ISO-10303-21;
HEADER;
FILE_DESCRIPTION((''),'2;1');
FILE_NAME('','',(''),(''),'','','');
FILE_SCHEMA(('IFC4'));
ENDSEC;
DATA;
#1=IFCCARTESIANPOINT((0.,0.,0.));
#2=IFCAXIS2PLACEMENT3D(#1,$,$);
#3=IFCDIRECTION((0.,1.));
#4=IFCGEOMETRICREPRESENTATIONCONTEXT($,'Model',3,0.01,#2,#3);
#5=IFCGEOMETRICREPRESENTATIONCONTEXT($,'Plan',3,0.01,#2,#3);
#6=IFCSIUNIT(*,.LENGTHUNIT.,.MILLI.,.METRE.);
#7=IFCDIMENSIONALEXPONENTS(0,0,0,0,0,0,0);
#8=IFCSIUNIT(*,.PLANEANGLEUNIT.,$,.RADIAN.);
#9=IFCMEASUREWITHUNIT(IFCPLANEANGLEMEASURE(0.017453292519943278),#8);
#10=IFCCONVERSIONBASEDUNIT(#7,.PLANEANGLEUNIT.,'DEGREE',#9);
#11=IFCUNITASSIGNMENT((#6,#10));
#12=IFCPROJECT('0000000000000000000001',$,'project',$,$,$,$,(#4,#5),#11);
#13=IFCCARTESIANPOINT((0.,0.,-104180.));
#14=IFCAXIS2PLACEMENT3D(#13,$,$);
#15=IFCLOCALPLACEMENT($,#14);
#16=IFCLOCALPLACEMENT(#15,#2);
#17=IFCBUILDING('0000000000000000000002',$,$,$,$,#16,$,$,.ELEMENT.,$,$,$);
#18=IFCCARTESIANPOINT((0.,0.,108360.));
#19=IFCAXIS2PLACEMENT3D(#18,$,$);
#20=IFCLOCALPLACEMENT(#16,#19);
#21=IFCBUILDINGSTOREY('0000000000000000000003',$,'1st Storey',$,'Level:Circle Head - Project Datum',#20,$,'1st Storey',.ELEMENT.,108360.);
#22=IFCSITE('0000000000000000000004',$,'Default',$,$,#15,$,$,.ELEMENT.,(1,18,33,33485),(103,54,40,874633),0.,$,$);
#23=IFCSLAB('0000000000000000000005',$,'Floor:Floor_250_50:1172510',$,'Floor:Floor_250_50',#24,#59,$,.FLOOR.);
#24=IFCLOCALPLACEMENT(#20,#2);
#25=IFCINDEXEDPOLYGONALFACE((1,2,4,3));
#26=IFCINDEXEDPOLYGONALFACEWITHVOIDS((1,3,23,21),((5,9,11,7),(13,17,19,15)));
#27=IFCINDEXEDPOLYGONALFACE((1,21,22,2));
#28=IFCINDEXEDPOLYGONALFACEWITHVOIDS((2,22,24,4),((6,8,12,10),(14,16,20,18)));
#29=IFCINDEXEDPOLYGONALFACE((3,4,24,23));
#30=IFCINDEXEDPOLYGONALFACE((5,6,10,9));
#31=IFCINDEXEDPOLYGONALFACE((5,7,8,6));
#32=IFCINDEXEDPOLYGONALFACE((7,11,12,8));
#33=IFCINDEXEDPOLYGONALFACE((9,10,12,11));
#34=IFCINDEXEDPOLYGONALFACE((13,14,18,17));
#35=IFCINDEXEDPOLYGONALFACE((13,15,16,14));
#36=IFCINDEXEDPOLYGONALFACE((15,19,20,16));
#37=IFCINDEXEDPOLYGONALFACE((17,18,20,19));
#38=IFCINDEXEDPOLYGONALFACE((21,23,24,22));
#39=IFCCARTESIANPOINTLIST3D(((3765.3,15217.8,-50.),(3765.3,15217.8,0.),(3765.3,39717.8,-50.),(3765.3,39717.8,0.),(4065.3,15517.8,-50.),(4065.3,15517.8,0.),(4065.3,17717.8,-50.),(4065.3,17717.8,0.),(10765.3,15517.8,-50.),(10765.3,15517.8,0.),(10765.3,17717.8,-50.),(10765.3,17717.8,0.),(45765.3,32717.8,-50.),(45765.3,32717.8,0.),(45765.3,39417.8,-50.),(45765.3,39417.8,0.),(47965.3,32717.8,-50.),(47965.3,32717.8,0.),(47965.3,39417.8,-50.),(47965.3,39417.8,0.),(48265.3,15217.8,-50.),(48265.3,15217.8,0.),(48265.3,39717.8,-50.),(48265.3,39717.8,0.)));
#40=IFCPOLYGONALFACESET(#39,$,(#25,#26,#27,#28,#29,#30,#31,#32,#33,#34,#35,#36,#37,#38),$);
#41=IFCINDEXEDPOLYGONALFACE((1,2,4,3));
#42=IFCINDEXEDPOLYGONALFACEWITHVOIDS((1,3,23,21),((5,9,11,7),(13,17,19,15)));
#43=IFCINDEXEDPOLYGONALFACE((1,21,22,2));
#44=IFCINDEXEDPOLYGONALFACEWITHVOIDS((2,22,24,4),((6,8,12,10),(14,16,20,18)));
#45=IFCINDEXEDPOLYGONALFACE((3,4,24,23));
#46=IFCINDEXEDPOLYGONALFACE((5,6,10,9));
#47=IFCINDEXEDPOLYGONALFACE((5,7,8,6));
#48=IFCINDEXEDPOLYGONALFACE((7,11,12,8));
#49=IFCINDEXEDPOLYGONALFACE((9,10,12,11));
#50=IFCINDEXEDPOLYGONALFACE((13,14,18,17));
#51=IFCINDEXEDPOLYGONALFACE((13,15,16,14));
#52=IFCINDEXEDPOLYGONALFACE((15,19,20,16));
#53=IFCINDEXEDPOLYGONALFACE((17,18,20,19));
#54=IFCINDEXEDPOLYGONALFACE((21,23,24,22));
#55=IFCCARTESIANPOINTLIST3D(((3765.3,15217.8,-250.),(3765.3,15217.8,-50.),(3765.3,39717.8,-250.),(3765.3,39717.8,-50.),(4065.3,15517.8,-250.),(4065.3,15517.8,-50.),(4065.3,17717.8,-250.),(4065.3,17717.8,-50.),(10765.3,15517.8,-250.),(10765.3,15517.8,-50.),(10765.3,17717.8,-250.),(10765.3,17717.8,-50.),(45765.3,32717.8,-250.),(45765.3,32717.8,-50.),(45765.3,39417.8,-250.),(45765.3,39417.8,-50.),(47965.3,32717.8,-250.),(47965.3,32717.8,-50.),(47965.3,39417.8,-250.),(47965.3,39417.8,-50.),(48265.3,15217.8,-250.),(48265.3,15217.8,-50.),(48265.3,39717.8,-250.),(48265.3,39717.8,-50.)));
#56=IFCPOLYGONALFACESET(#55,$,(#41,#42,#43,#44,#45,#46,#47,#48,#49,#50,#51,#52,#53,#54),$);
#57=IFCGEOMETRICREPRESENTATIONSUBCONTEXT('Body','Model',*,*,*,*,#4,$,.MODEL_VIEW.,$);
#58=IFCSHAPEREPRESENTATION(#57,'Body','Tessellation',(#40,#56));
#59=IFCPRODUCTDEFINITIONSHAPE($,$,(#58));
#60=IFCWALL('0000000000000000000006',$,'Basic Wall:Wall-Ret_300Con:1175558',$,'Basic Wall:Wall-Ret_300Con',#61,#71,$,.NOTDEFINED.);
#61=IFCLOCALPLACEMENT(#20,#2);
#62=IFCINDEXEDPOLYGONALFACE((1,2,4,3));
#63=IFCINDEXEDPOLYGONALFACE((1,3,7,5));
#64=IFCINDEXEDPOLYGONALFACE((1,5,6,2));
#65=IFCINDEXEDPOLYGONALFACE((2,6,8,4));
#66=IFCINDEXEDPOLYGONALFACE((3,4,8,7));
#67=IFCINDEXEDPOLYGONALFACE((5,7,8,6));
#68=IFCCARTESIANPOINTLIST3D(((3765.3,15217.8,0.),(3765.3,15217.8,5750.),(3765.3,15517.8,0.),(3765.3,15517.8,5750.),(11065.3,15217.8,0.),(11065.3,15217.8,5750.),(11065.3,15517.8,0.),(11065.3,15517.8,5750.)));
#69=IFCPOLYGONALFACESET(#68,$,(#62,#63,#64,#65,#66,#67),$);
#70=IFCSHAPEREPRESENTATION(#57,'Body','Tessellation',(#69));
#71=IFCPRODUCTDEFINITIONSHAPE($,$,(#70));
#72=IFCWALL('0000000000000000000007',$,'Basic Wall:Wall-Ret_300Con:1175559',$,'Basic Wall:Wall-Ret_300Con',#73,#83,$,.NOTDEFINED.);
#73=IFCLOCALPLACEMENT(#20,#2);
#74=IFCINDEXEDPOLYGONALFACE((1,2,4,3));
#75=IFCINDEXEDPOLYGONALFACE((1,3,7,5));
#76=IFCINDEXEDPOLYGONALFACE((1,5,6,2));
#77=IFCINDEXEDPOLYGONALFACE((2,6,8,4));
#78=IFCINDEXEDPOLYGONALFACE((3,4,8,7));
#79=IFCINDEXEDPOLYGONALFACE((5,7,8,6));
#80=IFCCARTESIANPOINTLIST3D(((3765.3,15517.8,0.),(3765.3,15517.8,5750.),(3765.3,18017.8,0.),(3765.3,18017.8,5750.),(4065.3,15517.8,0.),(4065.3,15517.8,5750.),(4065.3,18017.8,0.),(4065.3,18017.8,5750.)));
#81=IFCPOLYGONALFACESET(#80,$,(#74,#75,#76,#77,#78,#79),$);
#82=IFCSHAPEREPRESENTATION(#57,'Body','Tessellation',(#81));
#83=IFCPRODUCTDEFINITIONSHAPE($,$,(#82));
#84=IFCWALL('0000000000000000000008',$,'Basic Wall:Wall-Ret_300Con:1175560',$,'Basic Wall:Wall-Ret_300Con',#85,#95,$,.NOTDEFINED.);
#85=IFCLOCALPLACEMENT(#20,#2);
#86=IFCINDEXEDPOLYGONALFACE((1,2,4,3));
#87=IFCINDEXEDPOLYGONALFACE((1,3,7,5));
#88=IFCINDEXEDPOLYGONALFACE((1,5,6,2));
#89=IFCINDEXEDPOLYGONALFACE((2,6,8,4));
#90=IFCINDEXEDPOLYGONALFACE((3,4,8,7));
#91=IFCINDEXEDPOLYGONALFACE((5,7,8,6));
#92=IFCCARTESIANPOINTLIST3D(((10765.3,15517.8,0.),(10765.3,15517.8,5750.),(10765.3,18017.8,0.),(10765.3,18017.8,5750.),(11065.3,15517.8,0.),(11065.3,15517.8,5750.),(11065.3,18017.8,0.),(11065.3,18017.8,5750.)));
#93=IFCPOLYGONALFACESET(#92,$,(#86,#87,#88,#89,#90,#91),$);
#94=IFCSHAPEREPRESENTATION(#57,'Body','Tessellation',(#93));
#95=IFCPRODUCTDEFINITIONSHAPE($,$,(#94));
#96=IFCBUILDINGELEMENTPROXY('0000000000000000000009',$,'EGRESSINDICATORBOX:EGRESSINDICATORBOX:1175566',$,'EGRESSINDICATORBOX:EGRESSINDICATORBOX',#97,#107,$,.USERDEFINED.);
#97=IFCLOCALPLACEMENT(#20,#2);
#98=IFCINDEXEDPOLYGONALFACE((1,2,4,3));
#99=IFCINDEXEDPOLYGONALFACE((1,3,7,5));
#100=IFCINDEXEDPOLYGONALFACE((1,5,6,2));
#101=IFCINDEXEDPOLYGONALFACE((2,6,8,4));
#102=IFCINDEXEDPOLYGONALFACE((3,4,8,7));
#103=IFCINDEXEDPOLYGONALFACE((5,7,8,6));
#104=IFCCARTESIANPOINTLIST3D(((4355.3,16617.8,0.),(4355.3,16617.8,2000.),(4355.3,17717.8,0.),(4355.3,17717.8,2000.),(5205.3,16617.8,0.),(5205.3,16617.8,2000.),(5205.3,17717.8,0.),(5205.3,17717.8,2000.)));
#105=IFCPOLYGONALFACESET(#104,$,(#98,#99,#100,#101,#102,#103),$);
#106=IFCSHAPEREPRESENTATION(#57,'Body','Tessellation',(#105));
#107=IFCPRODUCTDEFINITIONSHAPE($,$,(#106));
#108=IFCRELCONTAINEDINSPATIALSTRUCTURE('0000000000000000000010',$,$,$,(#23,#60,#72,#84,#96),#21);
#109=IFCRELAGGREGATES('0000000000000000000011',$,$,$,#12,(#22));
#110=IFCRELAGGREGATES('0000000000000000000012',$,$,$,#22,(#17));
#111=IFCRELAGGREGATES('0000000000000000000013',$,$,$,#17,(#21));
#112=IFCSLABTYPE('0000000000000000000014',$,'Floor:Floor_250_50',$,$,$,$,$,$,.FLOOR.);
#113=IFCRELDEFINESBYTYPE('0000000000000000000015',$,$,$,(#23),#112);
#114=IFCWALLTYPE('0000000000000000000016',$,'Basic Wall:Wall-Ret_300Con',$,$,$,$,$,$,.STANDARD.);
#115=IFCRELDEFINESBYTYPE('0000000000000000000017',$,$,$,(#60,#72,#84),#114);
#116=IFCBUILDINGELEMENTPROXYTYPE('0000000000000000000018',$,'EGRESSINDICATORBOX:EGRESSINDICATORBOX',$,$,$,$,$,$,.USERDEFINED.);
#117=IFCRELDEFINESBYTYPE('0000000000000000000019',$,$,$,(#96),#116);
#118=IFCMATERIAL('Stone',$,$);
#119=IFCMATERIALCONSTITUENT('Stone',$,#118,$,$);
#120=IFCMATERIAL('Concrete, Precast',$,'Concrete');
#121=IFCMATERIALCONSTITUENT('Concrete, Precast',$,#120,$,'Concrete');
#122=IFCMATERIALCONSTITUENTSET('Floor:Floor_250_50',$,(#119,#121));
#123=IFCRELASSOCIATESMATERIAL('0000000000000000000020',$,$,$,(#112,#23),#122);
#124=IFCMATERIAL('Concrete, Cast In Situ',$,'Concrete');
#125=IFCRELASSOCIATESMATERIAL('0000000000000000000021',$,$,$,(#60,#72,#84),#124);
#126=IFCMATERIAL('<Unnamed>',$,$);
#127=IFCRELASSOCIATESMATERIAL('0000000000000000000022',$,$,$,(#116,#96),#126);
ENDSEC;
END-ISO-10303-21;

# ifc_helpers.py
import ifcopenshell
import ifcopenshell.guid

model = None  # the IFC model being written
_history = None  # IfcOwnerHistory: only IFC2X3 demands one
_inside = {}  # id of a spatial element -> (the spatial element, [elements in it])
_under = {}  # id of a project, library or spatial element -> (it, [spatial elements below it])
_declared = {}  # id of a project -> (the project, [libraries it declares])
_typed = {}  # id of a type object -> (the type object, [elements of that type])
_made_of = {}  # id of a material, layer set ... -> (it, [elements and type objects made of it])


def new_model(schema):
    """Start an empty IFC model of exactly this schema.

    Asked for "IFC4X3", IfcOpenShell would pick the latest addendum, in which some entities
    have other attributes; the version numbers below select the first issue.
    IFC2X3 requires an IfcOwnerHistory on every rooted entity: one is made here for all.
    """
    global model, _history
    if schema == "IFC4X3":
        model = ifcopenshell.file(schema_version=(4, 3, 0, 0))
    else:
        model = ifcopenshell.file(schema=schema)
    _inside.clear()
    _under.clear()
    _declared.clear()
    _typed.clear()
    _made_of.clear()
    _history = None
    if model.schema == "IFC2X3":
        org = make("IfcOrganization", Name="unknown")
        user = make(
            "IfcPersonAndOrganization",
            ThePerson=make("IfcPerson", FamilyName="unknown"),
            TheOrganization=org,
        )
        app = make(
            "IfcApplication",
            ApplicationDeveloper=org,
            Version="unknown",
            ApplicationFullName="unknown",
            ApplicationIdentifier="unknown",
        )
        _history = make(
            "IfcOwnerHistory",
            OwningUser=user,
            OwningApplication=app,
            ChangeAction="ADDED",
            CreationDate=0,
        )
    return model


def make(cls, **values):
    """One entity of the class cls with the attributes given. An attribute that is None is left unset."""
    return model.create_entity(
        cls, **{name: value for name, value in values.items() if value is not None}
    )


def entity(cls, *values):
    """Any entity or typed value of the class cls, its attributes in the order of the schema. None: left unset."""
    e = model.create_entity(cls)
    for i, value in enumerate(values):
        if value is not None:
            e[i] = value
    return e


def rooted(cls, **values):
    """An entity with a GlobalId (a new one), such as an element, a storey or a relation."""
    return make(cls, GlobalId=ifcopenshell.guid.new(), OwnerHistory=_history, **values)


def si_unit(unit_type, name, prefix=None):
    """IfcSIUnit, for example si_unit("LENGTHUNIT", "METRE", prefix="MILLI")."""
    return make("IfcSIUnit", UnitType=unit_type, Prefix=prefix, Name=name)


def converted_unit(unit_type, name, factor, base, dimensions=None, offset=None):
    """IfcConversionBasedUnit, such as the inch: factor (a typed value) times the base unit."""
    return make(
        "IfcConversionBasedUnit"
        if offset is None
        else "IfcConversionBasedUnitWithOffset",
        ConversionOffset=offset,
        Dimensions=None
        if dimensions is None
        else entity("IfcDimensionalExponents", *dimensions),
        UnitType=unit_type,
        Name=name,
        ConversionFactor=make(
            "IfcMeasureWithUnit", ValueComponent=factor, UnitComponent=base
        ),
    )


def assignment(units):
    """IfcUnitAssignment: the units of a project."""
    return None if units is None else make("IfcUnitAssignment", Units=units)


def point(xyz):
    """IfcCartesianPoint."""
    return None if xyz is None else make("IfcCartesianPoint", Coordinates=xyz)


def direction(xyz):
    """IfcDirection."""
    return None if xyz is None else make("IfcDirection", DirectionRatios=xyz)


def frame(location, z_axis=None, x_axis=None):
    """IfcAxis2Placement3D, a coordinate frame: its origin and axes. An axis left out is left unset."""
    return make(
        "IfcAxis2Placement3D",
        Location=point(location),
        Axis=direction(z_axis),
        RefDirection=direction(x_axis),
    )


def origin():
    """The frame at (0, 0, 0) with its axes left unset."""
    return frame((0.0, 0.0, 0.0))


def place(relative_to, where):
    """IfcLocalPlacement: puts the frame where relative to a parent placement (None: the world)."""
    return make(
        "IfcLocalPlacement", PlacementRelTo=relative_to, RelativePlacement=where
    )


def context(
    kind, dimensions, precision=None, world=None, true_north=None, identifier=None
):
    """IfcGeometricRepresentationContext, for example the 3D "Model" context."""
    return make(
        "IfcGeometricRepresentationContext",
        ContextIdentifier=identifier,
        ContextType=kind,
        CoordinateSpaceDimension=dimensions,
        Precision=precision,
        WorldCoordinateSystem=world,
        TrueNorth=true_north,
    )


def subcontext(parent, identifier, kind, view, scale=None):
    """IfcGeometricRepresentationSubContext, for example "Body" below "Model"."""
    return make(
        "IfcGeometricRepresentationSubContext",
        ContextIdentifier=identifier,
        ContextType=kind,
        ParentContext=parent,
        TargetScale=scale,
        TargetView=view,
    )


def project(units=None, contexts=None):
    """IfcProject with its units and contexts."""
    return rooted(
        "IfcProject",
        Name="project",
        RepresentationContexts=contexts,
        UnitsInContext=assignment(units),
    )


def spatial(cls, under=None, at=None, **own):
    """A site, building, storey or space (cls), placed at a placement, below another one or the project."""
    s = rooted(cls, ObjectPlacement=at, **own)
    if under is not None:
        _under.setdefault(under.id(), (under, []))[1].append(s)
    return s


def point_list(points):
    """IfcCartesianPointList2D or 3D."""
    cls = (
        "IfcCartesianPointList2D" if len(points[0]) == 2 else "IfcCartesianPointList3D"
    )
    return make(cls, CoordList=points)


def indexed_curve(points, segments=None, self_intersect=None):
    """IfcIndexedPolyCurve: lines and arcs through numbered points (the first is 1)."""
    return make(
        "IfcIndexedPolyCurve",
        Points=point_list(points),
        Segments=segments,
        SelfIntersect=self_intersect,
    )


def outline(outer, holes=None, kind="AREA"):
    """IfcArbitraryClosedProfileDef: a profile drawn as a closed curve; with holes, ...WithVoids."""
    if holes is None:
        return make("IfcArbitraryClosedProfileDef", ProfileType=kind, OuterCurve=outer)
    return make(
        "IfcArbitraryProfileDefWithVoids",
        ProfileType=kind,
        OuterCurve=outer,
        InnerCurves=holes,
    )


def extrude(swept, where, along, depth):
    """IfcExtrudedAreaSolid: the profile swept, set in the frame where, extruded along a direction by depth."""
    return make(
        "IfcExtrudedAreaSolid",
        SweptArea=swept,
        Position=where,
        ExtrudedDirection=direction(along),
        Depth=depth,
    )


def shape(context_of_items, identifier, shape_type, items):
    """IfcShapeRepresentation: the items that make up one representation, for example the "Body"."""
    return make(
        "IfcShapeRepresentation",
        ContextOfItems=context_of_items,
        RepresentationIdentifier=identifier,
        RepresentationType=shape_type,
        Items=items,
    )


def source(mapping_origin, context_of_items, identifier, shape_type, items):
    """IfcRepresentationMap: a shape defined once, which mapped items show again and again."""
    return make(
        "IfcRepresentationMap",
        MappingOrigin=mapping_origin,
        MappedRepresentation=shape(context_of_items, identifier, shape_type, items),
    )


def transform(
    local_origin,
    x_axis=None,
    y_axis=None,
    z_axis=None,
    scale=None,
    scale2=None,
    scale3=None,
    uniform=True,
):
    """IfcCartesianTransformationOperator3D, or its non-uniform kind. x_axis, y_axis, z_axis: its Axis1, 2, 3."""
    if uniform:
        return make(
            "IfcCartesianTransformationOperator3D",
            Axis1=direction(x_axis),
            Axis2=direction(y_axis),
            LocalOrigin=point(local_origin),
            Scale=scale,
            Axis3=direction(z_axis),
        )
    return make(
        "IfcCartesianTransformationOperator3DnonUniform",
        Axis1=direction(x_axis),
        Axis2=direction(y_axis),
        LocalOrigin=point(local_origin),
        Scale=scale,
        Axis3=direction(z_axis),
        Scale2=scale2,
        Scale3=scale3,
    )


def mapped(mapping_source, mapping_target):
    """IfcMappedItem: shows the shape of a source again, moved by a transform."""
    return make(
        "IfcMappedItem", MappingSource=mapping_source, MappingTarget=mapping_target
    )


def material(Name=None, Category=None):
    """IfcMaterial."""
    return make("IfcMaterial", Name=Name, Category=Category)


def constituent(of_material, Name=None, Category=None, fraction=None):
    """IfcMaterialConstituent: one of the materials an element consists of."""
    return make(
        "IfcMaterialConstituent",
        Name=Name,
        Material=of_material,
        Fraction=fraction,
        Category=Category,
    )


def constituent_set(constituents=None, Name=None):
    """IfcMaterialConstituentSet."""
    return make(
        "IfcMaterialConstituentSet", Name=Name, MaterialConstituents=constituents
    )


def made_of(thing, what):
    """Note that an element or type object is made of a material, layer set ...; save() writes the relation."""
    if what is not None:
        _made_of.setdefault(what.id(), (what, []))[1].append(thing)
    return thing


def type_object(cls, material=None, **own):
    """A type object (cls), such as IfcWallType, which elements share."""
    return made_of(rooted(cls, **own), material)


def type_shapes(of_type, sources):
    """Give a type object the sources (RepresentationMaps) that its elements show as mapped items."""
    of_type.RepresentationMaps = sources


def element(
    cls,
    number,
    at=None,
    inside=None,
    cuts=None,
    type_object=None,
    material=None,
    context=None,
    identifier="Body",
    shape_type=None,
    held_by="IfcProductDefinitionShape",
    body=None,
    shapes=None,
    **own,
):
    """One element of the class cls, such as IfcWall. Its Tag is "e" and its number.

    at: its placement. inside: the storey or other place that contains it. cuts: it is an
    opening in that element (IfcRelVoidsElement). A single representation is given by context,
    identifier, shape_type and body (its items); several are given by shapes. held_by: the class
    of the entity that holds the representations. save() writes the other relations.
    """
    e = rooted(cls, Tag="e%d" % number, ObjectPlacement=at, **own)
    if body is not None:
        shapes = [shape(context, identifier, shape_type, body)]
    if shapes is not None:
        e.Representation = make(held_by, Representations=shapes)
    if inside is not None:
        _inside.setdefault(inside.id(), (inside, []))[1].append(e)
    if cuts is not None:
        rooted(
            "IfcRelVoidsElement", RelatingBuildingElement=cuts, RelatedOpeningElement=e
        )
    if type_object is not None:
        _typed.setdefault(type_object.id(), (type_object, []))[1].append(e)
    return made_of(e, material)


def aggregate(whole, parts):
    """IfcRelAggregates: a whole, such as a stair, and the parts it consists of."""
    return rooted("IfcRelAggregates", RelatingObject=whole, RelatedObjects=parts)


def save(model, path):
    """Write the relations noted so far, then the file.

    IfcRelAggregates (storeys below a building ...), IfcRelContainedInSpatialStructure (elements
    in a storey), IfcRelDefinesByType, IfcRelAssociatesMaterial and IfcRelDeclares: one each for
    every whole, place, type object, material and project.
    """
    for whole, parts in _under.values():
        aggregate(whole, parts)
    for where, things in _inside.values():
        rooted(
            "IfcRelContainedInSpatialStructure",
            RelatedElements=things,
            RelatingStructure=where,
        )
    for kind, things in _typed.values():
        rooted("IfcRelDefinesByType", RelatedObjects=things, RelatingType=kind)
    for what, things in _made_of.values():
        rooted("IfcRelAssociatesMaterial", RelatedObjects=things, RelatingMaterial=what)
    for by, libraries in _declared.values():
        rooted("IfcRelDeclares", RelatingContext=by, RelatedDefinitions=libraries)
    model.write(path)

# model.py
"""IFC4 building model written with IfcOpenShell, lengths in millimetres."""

from ifc_helpers import new_model, entity, si_unit, converted_unit, direction, frame, origin, place, context, subcontext, project, spatial, indexed_curve, outline, extrude, source, transform, mapped, material, constituent, constituent_set, type_object, type_shapes, element, save


model = new_model("IFC4")

# Units and contexts
model_context = context("Model", 3, precision=0.01, world=origin(), true_north=direction((0.0, 1.0)))
plan_context = context("Plan", 3, precision=0.01, world=origin(), true_north=direction((0.0, 1.0)))
body_context = subcontext(model_context, "Body", "Model", "MODEL_VIEW")
ifc_project = project(units=[si_unit("LENGTHUNIT", "METRE", prefix="MILLI"), converted_unit("PLANEANGLEUNIT", "DEGREE", entity("IfcPlaneAngleMeasure", 0.017453292519943278), si_unit("PLANEANGLEUNIT", "RADIAN"), dimensions=[0, 0, 0, 0, 0, 0, 0])], contexts=[model_context, plan_context])

# Site, building, storey
site_placement = place(None, frame((0.0, 0.0, -104180.0)))
site = spatial("IfcSite", under=ifc_project, at=site_placement, Name="Default", CompositionType="ELEMENT", RefLatitude=(1, 18, 33, 33485), RefLongitude=(103, 54, 40, 874633), RefElevation=0.0)
building_placement = place(site_placement, origin())
building = spatial("IfcBuilding", under=site, at=building_placement, CompositionType="ELEMENT")
storey_placement = place(building_placement, frame((0.0, 0.0, 108360.0)))
storey = spatial("IfcBuildingStorey", under=building, at=storey_placement, Name="1st Storey", ObjectType="Level:Circle Head - Project Datum", LongName="1st Storey", CompositionType="ELEMENT", Elevation=108360.0)

# Slab, openings
ifc_material_1 = material(Name="Stone")
ifc_constituent_1 = constituent(ifc_material_1, Name="Stone")
ifc_material_2 = material(Name="Concrete, Precast", Category="Concrete")
ifc_constituent_2 = constituent(ifc_material_2, Name="Concrete, Precast", Category="Concrete")
ifc_constituent_set = constituent_set(constituents=[ifc_constituent_1, ifc_constituent_2], Name="Floor:Floor_250_50")
slab_type_1 = type_object("IfcSlabType", Name="Floor:Floor_250_50", PredefinedType="FLOOR", material=ifc_constituent_set)
slab_1_placement = place(storey_placement, origin())
slab_1 = element("IfcSlab", 1, at=slab_1_placement, inside=storey, type_object=slab_type_1, material=ifc_constituent_set, Name="Floor:Floor_250_50:1172510", ObjectType="Floor:Floor_250_50", PredefinedType="FLOOR", context=body_context, shape_type="SweptSolid", body=[
    extrude(outline(indexed_curve([(-22250.0, -12250.0), (22250.0, -12250.0), (22250.0, 12250.0), (-22250.0, 12250.0), (-22250.0, -12250.0)], self_intersect=False), holes=[indexed_curve([(-21950.0, -11950.0), (-21950.0, -5250.0), (-19750.0, -5250.0), (-19750.0, -11950.0), (-21950.0, -11950.0)], self_intersect=False), indexed_curve([(21950.0, 9750.0), (15250.0, 9750.0), (15250.0, 11950.0), (21950.0, 11950.0), (21950.0, 9750.0)], self_intersect=False)]), frame((26015.3, 27467.8, -50.0), z_axis=(0.0, 0.0, 1.0), x_axis=(-1.0, 0.0, 0.0)), (0.0, 0.0, 1.0), 50.0),
    extrude(outline(indexed_curve([(-22250.0, -12250.0), (22250.0, -12250.0), (22250.0, 12250.0), (-22250.0, 12250.0), (-22250.0, -12250.0)], self_intersect=False), holes=[indexed_curve([(21950.0, 9750.0), (15250.0, 9750.0), (15250.0, 11950.0), (21950.0, 11950.0), (21950.0, 9750.0)], self_intersect=False), indexed_curve([(-21950.0, -11950.0), (-21950.0, -5250.0), (-19750.0, -5250.0), (-19750.0, -11950.0), (-21950.0, -11950.0)], self_intersect=False)]), frame((26015.3, 27467.8, -250.0), z_axis=(0.0, 0.0, 1.0), x_axis=(-1.0, 0.0, 0.0)), (0.0, 0.0, 1.0), 200.0),
])
opening_1_placement = place(slab_1_placement, origin())
element("IfcOpeningElement", 2, at=opening_1_placement, cuts=slab_1, PredefinedType="OPENING", context=body_context, shape_type="SweptSolid", body=[
    extrude(outline(indexed_curve([(-3350.0, -1100.0), (3350.0, -1100.0), (3350.0, 1100.0), (-3350.0, 1100.0), (-3350.0, -1100.0)], self_intersect=False)), frame((7415.3, 16617.8, 0.0), z_axis=(0.0, 0.0, -1.0), x_axis=(1.0, 0.0, 0.0)), (0.0, 0.0, 1.0), 250.0),
])
opening_2_placement = place(slab_1_placement, origin())
element("IfcOpeningElement", 3, at=opening_2_placement, cuts=slab_1, PredefinedType="OPENING", context=body_context, shape_type="SweptSolid", body=[
    extrude(outline(indexed_curve([(-3350.0, -1100.0), (3350.0, -1100.0), (3350.0, 1100.0), (-3350.0, 1100.0), (-3350.0, -1100.0)], self_intersect=False)), frame((46865.3, 36067.8, 0.0), z_axis=(0.0, 0.0, -1.0), x_axis=(0.0, -1.0, 0.0)), (0.0, 0.0, 1.0), 250.0),
])

# Walls
ifc_material_3 = material(Name="Concrete, Cast In Situ", Category="Concrete")
wall_type = type_object("IfcWallType", Name="Basic Wall:Wall-Ret_300Con", PredefinedType="STANDARD")
wall_1_placement = place(storey_placement, frame((3765.3, 15367.8, 0.0)))
element("IfcWall", 4, at=wall_1_placement, inside=storey, type_object=wall_type, material=ifc_material_3, Name="Basic Wall:Wall-Ret_300Con:1175558", ObjectType="Basic Wall:Wall-Ret_300Con", PredefinedType="NOTDEFINED", context=body_context, shape_type="SweptSolid", body=[
    extrude(outline(indexed_curve([(7300.0, 150.0), (0.0, 150.0), (0.0, -150.0), (7300.0, -150.0), (7300.0, 150.0)], self_intersect=False)), origin(), (0.0, 0.0, 1.0), 5750.0),
])
wall_2_placement = place(storey_placement, frame((3915.3, 18017.8, 0.0), z_axis=(0.0, 0.0, 1.0), x_axis=(0.0, -1.0, 0.0)))
element("IfcWall", 5, at=wall_2_placement, inside=storey, type_object=wall_type, material=ifc_material_3, Name="Basic Wall:Wall-Ret_300Con:1175559", ObjectType="Basic Wall:Wall-Ret_300Con", PredefinedType="NOTDEFINED", context=body_context, shape_type="SweptSolid", body=[
    extrude(outline(indexed_curve([(2500.0, 150.0), (0.0, 150.0), (0.0, -150.0), (2500.0, -150.0), (2500.0, 150.0)], self_intersect=False)), origin(), (0.0, 0.0, 1.0), 5750.0),
])
wall_3_placement = place(storey_placement, frame((10915.3, 18017.8, 0.0), z_axis=(0.0, 0.0, 1.0), x_axis=(0.0, -1.0, 0.0)))
element("IfcWall", 6, at=wall_3_placement, inside=storey, type_object=wall_type, material=ifc_material_3, Name="Basic Wall:Wall-Ret_300Con:1175560", ObjectType="Basic Wall:Wall-Ret_300Con", PredefinedType="NOTDEFINED", context=body_context, shape_type="SweptSolid", body=[
    extrude(outline(indexed_curve([(2500.0, 150.0), (0.0, 150.0), (0.0, -150.0), (2500.0, -150.0), (2500.0, 150.0)], self_intersect=False)), origin(), (0.0, 0.0, 1.0), 5750.0),
])

# Building element proxy
ifc_material_4 = material(Name="<Unnamed>")
building_element_proxy_type = type_object("IfcBuildingElementProxyType", Name="EGRESSINDICATORBOX:EGRESSINDICATORBOX", PredefinedType="USERDEFINED", material=ifc_material_4)
shared_shape = source(origin(), body_context, "Body", "SweptSolid", [
    extrude(outline(indexed_curve([(-425.0, -550.0), (425.0, -550.0), (425.0, 550.0), (-425.0, 550.0), (-425.0, -550.0)], self_intersect=False)), frame((0.0, 0.0, 0.0), z_axis=(0.0, 0.0, 1.0), x_axis=(-1.0, 0.0, 0.0)), (0.0, 0.0, 1.0), 2000.0),
])
type_shapes(building_element_proxy_type, [shared_shape])
proxy_placement = place(storey_placement, frame((4780.3, 17167.8, 0.0), z_axis=(0.0, 0.0, 1.0), x_axis=(-1.0, 0.0, 0.0)))
element("IfcBuildingElementProxy", 7, at=proxy_placement, inside=storey, type_object=building_element_proxy_type, material=ifc_material_4, Name="EGRESSINDICATORBOX:EGRESSINDICATORBOX:1175566", ObjectType="EGRESSINDICATORBOX:EGRESSINDICATORBOX", PredefinedType="USERDEFINED", context=body_context, shape_type="MappedRepresentation", body=[
    mapped(shared_shape, transform((0.0, 0.0, 0.0), scale=1.0)),
])

save(model, "model.ifc")
